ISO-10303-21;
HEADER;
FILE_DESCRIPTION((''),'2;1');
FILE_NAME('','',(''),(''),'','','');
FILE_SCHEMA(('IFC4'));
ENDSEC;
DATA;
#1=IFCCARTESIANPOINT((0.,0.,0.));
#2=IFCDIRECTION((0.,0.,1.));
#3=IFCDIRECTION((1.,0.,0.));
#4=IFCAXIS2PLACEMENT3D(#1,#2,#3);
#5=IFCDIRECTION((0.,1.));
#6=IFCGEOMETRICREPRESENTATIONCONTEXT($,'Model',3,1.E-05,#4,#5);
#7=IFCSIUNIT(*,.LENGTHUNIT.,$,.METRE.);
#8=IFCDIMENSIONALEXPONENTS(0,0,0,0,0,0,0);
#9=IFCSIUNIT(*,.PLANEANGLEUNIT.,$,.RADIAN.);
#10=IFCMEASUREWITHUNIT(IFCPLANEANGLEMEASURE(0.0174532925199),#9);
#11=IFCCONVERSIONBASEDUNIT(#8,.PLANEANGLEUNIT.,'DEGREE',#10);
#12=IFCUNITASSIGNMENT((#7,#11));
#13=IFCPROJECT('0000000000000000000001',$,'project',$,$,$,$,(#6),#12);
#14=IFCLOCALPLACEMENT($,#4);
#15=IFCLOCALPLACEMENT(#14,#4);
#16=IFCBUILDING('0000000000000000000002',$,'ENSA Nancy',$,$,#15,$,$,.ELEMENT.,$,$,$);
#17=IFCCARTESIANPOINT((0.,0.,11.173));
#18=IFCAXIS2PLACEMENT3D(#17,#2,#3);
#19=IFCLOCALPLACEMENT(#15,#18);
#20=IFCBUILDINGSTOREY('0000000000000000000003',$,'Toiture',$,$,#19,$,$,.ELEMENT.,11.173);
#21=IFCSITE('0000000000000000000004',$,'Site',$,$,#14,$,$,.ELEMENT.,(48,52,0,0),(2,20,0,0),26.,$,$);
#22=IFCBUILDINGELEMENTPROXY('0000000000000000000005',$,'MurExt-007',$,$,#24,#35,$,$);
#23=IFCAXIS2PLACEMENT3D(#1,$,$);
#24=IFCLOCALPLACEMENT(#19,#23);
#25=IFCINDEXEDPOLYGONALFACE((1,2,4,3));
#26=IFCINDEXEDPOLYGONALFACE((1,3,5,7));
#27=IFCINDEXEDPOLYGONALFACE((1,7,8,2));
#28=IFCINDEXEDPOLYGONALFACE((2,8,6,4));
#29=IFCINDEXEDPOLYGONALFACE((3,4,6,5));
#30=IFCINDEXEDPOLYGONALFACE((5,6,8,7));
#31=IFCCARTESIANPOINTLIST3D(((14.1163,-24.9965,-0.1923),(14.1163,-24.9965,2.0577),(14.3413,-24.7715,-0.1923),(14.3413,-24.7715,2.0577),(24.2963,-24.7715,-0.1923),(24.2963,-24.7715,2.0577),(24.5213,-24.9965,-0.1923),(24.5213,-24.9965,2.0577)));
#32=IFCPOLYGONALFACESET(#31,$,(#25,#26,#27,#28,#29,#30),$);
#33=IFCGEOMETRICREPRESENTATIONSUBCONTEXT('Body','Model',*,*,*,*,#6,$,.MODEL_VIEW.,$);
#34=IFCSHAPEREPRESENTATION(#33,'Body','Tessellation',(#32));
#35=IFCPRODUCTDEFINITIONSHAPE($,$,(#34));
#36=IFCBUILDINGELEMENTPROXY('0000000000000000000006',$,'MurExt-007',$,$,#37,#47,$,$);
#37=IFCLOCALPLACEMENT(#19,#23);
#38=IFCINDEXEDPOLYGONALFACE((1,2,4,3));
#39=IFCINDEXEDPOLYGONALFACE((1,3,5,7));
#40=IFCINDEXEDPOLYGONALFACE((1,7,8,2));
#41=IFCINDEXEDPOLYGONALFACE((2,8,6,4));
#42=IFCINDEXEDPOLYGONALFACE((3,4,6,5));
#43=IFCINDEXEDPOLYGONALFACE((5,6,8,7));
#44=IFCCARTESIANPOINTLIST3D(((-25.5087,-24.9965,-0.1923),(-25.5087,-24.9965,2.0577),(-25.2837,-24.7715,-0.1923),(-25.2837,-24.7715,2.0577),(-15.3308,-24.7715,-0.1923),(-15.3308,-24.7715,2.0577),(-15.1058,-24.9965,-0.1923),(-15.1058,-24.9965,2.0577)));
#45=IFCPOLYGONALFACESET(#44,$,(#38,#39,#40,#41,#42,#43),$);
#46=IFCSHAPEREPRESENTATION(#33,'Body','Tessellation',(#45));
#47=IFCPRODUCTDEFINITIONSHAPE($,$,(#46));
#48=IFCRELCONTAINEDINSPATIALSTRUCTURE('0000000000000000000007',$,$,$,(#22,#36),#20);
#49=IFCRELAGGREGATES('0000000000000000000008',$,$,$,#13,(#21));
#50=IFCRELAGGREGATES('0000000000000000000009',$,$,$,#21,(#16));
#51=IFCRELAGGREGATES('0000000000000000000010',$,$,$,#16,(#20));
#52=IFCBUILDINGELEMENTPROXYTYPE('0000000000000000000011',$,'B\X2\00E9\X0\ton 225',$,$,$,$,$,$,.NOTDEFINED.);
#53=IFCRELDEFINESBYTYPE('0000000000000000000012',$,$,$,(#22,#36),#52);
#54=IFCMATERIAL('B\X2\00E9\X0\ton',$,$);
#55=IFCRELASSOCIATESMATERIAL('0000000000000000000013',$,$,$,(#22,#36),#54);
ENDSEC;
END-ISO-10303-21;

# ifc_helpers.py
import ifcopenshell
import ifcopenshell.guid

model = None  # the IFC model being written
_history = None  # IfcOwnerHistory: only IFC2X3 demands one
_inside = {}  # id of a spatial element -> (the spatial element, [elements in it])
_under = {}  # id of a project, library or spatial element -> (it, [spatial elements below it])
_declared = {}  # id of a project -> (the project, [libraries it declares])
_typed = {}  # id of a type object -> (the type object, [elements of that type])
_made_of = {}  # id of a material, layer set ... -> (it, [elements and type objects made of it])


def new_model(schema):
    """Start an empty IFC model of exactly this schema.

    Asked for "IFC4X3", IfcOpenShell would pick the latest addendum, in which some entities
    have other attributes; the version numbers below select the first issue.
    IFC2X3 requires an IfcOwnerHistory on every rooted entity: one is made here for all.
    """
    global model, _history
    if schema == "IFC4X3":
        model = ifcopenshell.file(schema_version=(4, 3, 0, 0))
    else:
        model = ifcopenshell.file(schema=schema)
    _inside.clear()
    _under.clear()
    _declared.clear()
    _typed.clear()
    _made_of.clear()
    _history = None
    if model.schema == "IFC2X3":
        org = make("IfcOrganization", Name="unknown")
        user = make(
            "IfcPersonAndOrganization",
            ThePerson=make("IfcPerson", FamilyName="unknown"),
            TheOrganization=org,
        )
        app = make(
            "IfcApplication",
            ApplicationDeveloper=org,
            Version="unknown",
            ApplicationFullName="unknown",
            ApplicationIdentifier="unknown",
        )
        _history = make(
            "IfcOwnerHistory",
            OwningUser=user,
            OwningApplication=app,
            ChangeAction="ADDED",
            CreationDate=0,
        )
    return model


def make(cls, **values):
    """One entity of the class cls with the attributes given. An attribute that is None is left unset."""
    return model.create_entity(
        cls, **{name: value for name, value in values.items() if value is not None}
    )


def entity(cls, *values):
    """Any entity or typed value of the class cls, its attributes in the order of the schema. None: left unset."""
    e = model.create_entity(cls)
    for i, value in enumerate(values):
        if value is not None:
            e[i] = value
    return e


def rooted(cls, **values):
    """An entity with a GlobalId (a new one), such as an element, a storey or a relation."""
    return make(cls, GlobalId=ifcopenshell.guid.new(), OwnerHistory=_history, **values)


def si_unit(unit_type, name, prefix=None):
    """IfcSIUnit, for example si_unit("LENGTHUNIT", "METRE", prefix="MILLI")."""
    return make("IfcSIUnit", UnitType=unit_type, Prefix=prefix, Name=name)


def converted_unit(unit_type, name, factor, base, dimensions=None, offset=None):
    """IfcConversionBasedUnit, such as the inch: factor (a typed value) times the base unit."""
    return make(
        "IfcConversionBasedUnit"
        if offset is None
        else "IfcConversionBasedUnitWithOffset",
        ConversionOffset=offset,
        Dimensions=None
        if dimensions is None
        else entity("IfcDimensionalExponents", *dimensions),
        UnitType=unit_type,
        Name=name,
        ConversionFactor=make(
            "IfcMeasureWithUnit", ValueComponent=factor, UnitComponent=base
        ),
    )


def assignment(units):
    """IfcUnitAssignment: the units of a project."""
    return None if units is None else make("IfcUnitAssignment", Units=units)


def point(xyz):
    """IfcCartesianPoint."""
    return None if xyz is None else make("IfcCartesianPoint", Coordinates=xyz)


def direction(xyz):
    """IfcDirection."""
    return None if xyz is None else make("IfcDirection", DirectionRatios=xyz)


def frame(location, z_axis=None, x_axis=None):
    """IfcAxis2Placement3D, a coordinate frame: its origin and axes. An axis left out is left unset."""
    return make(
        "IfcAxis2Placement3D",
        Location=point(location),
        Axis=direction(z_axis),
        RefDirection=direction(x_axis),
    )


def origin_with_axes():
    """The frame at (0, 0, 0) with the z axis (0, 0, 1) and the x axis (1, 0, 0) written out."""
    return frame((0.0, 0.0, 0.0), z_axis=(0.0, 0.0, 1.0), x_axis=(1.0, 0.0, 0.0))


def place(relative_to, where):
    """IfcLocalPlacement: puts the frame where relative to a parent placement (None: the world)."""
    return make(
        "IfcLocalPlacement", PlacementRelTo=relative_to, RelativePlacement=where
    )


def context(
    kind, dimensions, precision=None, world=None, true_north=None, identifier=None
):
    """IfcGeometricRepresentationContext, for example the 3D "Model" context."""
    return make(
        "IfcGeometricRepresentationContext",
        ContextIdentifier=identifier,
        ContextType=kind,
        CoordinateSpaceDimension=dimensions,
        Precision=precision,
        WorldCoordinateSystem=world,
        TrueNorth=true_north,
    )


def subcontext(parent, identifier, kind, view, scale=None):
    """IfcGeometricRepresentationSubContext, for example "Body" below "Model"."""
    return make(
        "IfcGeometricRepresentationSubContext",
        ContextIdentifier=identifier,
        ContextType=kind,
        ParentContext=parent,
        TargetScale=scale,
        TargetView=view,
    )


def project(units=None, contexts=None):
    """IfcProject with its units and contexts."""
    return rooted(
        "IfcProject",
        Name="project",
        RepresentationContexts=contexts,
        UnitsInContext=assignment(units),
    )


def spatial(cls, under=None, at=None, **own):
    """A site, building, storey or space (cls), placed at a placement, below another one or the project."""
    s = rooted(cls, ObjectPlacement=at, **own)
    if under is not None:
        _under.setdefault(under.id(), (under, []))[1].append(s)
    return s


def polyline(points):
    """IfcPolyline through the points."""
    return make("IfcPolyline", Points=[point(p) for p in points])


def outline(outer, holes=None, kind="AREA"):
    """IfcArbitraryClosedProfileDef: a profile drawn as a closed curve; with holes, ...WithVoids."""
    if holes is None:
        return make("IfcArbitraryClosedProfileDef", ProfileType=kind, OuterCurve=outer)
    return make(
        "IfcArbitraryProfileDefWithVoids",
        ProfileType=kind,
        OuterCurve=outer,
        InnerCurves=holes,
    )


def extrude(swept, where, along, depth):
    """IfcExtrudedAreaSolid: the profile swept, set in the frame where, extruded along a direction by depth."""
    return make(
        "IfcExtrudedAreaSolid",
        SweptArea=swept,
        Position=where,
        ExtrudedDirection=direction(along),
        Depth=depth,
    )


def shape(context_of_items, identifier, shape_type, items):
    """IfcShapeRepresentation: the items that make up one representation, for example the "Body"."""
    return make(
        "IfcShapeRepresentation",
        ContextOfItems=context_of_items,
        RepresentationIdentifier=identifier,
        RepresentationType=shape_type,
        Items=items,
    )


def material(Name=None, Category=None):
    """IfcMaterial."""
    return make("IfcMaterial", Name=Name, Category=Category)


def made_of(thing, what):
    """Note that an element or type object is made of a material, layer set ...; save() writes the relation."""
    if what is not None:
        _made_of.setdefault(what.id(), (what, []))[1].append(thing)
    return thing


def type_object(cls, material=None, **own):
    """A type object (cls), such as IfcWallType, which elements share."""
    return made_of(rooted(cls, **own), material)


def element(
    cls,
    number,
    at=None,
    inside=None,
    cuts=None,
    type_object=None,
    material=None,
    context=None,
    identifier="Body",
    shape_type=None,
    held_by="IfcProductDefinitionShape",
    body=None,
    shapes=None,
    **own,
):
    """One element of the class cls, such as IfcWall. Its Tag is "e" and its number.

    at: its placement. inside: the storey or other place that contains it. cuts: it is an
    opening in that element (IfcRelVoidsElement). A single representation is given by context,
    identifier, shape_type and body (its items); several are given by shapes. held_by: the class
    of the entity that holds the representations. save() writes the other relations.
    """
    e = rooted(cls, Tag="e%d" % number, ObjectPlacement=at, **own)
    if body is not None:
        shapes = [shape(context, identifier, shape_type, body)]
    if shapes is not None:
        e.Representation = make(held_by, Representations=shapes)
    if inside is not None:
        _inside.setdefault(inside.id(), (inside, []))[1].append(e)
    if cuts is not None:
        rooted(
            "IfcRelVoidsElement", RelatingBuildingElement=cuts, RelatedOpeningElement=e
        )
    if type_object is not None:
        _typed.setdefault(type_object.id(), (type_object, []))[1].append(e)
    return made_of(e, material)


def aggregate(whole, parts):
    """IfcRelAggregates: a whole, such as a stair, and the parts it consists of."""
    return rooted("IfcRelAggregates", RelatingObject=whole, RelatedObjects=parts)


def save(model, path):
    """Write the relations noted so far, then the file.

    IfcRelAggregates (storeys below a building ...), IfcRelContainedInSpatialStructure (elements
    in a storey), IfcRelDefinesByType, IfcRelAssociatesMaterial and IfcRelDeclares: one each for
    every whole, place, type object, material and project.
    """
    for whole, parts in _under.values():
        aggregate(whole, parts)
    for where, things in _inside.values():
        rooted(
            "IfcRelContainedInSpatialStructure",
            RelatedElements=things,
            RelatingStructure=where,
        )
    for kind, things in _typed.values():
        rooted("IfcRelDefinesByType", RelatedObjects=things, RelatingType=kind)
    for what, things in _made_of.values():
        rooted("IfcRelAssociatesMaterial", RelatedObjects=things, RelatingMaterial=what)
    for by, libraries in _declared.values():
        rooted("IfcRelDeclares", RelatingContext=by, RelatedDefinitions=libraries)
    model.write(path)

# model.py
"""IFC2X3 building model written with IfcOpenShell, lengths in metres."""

from ifc_helpers import new_model, entity, si_unit, converted_unit, direction, frame, origin_with_axes, place, context, subcontext, project, spatial, polyline, outline, extrude, material, type_object, element, save


model = new_model("IFC2X3")

# Units and contexts
model_context = context("Model", 3, precision=1e-05, world=origin_with_axes(), true_north=direction((0.0, 1.0)))
body_context = subcontext(model_context, "Body", "Model", "MODEL_VIEW")
ifc_project = project(units=[si_unit("LENGTHUNIT", "METRE"), converted_unit("PLANEANGLEUNIT", "DEGREE", entity("IfcPlaneAngleMeasure", 0.0174532925199), si_unit("PLANEANGLEUNIT", "RADIAN"), dimensions=[0, 0, 0, 0, 0, 0, 0])], contexts=[model_context])

# Site, building, storey
site_placement = place(None, origin_with_axes())
site = spatial("IfcSite", under=ifc_project, at=site_placement, Name="Site", CompositionType="ELEMENT", RefLatitude=(48, 52, 0, 0), RefLongitude=(2, 20, 0, 0), RefElevation=26.0)
building_placement = place(site_placement, origin_with_axes())
building = spatial("IfcBuilding", under=site, at=building_placement, Name="ENSA Nancy", CompositionType="ELEMENT")
storey_placement = place(building_placement, frame((0.0, 0.0, 11.173), z_axis=(0.0, 0.0, 1.0), x_axis=(1.0, 0.0, 0.0)))
storey = spatial("IfcBuildingStorey", under=building, at=storey_placement, Name="Toiture", CompositionType="ELEMENT", Elevation=11.173)

# Shared definitions
ifc_material_1 = material(Name="Béton")

# Building element proxies
building_element_proxy_type = type_object("IfcBuildingElementProxyType", Name="Béton 225", PredefinedType="NOTDEFINED")
proxy_1_placement = place(storey_placement, frame((14.1163, -24.9965, -0.1923), z_axis=(0.0, 0.0, 1.0), x_axis=(1.0, 0.0, 0.0)))
element("IfcBuildingElementProxy", 1, at=proxy_1_placement, inside=storey, type_object=building_element_proxy_type, material=ifc_material_1, Name="MurExt-007", context=body_context, shape_type="SweptSolid", body=[
    extrude(outline(polyline([(0.0, 0.0), (10.405, 0.0), (10.18, 0.225), (0.225, 0.225), (0.0, 0.0)])), origin_with_axes(), (0.0, 0.0, 1.0), 2.25),
])
proxy_2_placement = place(storey_placement, frame((-15.1058, -24.9965, -0.1923), z_axis=(0.0, 0.0, 1.0), x_axis=(-1.0, 0.0, 0.0)))
element("IfcBuildingElementProxy", 2, at=proxy_2_placement, inside=storey, type_object=building_element_proxy_type, material=ifc_material_1, Name="MurExt-007", context=body_context, shape_type="SweptSolid", body=[
    extrude(outline(polyline([(0.225, -0.225), (10.1779, -0.225), (10.4029, 0.0), (0.0, 0.0), (0.225, -0.225)])), origin_with_axes(), (0.0, 0.0, 1.0), 2.25),
])

save(model, "model.ifc")
